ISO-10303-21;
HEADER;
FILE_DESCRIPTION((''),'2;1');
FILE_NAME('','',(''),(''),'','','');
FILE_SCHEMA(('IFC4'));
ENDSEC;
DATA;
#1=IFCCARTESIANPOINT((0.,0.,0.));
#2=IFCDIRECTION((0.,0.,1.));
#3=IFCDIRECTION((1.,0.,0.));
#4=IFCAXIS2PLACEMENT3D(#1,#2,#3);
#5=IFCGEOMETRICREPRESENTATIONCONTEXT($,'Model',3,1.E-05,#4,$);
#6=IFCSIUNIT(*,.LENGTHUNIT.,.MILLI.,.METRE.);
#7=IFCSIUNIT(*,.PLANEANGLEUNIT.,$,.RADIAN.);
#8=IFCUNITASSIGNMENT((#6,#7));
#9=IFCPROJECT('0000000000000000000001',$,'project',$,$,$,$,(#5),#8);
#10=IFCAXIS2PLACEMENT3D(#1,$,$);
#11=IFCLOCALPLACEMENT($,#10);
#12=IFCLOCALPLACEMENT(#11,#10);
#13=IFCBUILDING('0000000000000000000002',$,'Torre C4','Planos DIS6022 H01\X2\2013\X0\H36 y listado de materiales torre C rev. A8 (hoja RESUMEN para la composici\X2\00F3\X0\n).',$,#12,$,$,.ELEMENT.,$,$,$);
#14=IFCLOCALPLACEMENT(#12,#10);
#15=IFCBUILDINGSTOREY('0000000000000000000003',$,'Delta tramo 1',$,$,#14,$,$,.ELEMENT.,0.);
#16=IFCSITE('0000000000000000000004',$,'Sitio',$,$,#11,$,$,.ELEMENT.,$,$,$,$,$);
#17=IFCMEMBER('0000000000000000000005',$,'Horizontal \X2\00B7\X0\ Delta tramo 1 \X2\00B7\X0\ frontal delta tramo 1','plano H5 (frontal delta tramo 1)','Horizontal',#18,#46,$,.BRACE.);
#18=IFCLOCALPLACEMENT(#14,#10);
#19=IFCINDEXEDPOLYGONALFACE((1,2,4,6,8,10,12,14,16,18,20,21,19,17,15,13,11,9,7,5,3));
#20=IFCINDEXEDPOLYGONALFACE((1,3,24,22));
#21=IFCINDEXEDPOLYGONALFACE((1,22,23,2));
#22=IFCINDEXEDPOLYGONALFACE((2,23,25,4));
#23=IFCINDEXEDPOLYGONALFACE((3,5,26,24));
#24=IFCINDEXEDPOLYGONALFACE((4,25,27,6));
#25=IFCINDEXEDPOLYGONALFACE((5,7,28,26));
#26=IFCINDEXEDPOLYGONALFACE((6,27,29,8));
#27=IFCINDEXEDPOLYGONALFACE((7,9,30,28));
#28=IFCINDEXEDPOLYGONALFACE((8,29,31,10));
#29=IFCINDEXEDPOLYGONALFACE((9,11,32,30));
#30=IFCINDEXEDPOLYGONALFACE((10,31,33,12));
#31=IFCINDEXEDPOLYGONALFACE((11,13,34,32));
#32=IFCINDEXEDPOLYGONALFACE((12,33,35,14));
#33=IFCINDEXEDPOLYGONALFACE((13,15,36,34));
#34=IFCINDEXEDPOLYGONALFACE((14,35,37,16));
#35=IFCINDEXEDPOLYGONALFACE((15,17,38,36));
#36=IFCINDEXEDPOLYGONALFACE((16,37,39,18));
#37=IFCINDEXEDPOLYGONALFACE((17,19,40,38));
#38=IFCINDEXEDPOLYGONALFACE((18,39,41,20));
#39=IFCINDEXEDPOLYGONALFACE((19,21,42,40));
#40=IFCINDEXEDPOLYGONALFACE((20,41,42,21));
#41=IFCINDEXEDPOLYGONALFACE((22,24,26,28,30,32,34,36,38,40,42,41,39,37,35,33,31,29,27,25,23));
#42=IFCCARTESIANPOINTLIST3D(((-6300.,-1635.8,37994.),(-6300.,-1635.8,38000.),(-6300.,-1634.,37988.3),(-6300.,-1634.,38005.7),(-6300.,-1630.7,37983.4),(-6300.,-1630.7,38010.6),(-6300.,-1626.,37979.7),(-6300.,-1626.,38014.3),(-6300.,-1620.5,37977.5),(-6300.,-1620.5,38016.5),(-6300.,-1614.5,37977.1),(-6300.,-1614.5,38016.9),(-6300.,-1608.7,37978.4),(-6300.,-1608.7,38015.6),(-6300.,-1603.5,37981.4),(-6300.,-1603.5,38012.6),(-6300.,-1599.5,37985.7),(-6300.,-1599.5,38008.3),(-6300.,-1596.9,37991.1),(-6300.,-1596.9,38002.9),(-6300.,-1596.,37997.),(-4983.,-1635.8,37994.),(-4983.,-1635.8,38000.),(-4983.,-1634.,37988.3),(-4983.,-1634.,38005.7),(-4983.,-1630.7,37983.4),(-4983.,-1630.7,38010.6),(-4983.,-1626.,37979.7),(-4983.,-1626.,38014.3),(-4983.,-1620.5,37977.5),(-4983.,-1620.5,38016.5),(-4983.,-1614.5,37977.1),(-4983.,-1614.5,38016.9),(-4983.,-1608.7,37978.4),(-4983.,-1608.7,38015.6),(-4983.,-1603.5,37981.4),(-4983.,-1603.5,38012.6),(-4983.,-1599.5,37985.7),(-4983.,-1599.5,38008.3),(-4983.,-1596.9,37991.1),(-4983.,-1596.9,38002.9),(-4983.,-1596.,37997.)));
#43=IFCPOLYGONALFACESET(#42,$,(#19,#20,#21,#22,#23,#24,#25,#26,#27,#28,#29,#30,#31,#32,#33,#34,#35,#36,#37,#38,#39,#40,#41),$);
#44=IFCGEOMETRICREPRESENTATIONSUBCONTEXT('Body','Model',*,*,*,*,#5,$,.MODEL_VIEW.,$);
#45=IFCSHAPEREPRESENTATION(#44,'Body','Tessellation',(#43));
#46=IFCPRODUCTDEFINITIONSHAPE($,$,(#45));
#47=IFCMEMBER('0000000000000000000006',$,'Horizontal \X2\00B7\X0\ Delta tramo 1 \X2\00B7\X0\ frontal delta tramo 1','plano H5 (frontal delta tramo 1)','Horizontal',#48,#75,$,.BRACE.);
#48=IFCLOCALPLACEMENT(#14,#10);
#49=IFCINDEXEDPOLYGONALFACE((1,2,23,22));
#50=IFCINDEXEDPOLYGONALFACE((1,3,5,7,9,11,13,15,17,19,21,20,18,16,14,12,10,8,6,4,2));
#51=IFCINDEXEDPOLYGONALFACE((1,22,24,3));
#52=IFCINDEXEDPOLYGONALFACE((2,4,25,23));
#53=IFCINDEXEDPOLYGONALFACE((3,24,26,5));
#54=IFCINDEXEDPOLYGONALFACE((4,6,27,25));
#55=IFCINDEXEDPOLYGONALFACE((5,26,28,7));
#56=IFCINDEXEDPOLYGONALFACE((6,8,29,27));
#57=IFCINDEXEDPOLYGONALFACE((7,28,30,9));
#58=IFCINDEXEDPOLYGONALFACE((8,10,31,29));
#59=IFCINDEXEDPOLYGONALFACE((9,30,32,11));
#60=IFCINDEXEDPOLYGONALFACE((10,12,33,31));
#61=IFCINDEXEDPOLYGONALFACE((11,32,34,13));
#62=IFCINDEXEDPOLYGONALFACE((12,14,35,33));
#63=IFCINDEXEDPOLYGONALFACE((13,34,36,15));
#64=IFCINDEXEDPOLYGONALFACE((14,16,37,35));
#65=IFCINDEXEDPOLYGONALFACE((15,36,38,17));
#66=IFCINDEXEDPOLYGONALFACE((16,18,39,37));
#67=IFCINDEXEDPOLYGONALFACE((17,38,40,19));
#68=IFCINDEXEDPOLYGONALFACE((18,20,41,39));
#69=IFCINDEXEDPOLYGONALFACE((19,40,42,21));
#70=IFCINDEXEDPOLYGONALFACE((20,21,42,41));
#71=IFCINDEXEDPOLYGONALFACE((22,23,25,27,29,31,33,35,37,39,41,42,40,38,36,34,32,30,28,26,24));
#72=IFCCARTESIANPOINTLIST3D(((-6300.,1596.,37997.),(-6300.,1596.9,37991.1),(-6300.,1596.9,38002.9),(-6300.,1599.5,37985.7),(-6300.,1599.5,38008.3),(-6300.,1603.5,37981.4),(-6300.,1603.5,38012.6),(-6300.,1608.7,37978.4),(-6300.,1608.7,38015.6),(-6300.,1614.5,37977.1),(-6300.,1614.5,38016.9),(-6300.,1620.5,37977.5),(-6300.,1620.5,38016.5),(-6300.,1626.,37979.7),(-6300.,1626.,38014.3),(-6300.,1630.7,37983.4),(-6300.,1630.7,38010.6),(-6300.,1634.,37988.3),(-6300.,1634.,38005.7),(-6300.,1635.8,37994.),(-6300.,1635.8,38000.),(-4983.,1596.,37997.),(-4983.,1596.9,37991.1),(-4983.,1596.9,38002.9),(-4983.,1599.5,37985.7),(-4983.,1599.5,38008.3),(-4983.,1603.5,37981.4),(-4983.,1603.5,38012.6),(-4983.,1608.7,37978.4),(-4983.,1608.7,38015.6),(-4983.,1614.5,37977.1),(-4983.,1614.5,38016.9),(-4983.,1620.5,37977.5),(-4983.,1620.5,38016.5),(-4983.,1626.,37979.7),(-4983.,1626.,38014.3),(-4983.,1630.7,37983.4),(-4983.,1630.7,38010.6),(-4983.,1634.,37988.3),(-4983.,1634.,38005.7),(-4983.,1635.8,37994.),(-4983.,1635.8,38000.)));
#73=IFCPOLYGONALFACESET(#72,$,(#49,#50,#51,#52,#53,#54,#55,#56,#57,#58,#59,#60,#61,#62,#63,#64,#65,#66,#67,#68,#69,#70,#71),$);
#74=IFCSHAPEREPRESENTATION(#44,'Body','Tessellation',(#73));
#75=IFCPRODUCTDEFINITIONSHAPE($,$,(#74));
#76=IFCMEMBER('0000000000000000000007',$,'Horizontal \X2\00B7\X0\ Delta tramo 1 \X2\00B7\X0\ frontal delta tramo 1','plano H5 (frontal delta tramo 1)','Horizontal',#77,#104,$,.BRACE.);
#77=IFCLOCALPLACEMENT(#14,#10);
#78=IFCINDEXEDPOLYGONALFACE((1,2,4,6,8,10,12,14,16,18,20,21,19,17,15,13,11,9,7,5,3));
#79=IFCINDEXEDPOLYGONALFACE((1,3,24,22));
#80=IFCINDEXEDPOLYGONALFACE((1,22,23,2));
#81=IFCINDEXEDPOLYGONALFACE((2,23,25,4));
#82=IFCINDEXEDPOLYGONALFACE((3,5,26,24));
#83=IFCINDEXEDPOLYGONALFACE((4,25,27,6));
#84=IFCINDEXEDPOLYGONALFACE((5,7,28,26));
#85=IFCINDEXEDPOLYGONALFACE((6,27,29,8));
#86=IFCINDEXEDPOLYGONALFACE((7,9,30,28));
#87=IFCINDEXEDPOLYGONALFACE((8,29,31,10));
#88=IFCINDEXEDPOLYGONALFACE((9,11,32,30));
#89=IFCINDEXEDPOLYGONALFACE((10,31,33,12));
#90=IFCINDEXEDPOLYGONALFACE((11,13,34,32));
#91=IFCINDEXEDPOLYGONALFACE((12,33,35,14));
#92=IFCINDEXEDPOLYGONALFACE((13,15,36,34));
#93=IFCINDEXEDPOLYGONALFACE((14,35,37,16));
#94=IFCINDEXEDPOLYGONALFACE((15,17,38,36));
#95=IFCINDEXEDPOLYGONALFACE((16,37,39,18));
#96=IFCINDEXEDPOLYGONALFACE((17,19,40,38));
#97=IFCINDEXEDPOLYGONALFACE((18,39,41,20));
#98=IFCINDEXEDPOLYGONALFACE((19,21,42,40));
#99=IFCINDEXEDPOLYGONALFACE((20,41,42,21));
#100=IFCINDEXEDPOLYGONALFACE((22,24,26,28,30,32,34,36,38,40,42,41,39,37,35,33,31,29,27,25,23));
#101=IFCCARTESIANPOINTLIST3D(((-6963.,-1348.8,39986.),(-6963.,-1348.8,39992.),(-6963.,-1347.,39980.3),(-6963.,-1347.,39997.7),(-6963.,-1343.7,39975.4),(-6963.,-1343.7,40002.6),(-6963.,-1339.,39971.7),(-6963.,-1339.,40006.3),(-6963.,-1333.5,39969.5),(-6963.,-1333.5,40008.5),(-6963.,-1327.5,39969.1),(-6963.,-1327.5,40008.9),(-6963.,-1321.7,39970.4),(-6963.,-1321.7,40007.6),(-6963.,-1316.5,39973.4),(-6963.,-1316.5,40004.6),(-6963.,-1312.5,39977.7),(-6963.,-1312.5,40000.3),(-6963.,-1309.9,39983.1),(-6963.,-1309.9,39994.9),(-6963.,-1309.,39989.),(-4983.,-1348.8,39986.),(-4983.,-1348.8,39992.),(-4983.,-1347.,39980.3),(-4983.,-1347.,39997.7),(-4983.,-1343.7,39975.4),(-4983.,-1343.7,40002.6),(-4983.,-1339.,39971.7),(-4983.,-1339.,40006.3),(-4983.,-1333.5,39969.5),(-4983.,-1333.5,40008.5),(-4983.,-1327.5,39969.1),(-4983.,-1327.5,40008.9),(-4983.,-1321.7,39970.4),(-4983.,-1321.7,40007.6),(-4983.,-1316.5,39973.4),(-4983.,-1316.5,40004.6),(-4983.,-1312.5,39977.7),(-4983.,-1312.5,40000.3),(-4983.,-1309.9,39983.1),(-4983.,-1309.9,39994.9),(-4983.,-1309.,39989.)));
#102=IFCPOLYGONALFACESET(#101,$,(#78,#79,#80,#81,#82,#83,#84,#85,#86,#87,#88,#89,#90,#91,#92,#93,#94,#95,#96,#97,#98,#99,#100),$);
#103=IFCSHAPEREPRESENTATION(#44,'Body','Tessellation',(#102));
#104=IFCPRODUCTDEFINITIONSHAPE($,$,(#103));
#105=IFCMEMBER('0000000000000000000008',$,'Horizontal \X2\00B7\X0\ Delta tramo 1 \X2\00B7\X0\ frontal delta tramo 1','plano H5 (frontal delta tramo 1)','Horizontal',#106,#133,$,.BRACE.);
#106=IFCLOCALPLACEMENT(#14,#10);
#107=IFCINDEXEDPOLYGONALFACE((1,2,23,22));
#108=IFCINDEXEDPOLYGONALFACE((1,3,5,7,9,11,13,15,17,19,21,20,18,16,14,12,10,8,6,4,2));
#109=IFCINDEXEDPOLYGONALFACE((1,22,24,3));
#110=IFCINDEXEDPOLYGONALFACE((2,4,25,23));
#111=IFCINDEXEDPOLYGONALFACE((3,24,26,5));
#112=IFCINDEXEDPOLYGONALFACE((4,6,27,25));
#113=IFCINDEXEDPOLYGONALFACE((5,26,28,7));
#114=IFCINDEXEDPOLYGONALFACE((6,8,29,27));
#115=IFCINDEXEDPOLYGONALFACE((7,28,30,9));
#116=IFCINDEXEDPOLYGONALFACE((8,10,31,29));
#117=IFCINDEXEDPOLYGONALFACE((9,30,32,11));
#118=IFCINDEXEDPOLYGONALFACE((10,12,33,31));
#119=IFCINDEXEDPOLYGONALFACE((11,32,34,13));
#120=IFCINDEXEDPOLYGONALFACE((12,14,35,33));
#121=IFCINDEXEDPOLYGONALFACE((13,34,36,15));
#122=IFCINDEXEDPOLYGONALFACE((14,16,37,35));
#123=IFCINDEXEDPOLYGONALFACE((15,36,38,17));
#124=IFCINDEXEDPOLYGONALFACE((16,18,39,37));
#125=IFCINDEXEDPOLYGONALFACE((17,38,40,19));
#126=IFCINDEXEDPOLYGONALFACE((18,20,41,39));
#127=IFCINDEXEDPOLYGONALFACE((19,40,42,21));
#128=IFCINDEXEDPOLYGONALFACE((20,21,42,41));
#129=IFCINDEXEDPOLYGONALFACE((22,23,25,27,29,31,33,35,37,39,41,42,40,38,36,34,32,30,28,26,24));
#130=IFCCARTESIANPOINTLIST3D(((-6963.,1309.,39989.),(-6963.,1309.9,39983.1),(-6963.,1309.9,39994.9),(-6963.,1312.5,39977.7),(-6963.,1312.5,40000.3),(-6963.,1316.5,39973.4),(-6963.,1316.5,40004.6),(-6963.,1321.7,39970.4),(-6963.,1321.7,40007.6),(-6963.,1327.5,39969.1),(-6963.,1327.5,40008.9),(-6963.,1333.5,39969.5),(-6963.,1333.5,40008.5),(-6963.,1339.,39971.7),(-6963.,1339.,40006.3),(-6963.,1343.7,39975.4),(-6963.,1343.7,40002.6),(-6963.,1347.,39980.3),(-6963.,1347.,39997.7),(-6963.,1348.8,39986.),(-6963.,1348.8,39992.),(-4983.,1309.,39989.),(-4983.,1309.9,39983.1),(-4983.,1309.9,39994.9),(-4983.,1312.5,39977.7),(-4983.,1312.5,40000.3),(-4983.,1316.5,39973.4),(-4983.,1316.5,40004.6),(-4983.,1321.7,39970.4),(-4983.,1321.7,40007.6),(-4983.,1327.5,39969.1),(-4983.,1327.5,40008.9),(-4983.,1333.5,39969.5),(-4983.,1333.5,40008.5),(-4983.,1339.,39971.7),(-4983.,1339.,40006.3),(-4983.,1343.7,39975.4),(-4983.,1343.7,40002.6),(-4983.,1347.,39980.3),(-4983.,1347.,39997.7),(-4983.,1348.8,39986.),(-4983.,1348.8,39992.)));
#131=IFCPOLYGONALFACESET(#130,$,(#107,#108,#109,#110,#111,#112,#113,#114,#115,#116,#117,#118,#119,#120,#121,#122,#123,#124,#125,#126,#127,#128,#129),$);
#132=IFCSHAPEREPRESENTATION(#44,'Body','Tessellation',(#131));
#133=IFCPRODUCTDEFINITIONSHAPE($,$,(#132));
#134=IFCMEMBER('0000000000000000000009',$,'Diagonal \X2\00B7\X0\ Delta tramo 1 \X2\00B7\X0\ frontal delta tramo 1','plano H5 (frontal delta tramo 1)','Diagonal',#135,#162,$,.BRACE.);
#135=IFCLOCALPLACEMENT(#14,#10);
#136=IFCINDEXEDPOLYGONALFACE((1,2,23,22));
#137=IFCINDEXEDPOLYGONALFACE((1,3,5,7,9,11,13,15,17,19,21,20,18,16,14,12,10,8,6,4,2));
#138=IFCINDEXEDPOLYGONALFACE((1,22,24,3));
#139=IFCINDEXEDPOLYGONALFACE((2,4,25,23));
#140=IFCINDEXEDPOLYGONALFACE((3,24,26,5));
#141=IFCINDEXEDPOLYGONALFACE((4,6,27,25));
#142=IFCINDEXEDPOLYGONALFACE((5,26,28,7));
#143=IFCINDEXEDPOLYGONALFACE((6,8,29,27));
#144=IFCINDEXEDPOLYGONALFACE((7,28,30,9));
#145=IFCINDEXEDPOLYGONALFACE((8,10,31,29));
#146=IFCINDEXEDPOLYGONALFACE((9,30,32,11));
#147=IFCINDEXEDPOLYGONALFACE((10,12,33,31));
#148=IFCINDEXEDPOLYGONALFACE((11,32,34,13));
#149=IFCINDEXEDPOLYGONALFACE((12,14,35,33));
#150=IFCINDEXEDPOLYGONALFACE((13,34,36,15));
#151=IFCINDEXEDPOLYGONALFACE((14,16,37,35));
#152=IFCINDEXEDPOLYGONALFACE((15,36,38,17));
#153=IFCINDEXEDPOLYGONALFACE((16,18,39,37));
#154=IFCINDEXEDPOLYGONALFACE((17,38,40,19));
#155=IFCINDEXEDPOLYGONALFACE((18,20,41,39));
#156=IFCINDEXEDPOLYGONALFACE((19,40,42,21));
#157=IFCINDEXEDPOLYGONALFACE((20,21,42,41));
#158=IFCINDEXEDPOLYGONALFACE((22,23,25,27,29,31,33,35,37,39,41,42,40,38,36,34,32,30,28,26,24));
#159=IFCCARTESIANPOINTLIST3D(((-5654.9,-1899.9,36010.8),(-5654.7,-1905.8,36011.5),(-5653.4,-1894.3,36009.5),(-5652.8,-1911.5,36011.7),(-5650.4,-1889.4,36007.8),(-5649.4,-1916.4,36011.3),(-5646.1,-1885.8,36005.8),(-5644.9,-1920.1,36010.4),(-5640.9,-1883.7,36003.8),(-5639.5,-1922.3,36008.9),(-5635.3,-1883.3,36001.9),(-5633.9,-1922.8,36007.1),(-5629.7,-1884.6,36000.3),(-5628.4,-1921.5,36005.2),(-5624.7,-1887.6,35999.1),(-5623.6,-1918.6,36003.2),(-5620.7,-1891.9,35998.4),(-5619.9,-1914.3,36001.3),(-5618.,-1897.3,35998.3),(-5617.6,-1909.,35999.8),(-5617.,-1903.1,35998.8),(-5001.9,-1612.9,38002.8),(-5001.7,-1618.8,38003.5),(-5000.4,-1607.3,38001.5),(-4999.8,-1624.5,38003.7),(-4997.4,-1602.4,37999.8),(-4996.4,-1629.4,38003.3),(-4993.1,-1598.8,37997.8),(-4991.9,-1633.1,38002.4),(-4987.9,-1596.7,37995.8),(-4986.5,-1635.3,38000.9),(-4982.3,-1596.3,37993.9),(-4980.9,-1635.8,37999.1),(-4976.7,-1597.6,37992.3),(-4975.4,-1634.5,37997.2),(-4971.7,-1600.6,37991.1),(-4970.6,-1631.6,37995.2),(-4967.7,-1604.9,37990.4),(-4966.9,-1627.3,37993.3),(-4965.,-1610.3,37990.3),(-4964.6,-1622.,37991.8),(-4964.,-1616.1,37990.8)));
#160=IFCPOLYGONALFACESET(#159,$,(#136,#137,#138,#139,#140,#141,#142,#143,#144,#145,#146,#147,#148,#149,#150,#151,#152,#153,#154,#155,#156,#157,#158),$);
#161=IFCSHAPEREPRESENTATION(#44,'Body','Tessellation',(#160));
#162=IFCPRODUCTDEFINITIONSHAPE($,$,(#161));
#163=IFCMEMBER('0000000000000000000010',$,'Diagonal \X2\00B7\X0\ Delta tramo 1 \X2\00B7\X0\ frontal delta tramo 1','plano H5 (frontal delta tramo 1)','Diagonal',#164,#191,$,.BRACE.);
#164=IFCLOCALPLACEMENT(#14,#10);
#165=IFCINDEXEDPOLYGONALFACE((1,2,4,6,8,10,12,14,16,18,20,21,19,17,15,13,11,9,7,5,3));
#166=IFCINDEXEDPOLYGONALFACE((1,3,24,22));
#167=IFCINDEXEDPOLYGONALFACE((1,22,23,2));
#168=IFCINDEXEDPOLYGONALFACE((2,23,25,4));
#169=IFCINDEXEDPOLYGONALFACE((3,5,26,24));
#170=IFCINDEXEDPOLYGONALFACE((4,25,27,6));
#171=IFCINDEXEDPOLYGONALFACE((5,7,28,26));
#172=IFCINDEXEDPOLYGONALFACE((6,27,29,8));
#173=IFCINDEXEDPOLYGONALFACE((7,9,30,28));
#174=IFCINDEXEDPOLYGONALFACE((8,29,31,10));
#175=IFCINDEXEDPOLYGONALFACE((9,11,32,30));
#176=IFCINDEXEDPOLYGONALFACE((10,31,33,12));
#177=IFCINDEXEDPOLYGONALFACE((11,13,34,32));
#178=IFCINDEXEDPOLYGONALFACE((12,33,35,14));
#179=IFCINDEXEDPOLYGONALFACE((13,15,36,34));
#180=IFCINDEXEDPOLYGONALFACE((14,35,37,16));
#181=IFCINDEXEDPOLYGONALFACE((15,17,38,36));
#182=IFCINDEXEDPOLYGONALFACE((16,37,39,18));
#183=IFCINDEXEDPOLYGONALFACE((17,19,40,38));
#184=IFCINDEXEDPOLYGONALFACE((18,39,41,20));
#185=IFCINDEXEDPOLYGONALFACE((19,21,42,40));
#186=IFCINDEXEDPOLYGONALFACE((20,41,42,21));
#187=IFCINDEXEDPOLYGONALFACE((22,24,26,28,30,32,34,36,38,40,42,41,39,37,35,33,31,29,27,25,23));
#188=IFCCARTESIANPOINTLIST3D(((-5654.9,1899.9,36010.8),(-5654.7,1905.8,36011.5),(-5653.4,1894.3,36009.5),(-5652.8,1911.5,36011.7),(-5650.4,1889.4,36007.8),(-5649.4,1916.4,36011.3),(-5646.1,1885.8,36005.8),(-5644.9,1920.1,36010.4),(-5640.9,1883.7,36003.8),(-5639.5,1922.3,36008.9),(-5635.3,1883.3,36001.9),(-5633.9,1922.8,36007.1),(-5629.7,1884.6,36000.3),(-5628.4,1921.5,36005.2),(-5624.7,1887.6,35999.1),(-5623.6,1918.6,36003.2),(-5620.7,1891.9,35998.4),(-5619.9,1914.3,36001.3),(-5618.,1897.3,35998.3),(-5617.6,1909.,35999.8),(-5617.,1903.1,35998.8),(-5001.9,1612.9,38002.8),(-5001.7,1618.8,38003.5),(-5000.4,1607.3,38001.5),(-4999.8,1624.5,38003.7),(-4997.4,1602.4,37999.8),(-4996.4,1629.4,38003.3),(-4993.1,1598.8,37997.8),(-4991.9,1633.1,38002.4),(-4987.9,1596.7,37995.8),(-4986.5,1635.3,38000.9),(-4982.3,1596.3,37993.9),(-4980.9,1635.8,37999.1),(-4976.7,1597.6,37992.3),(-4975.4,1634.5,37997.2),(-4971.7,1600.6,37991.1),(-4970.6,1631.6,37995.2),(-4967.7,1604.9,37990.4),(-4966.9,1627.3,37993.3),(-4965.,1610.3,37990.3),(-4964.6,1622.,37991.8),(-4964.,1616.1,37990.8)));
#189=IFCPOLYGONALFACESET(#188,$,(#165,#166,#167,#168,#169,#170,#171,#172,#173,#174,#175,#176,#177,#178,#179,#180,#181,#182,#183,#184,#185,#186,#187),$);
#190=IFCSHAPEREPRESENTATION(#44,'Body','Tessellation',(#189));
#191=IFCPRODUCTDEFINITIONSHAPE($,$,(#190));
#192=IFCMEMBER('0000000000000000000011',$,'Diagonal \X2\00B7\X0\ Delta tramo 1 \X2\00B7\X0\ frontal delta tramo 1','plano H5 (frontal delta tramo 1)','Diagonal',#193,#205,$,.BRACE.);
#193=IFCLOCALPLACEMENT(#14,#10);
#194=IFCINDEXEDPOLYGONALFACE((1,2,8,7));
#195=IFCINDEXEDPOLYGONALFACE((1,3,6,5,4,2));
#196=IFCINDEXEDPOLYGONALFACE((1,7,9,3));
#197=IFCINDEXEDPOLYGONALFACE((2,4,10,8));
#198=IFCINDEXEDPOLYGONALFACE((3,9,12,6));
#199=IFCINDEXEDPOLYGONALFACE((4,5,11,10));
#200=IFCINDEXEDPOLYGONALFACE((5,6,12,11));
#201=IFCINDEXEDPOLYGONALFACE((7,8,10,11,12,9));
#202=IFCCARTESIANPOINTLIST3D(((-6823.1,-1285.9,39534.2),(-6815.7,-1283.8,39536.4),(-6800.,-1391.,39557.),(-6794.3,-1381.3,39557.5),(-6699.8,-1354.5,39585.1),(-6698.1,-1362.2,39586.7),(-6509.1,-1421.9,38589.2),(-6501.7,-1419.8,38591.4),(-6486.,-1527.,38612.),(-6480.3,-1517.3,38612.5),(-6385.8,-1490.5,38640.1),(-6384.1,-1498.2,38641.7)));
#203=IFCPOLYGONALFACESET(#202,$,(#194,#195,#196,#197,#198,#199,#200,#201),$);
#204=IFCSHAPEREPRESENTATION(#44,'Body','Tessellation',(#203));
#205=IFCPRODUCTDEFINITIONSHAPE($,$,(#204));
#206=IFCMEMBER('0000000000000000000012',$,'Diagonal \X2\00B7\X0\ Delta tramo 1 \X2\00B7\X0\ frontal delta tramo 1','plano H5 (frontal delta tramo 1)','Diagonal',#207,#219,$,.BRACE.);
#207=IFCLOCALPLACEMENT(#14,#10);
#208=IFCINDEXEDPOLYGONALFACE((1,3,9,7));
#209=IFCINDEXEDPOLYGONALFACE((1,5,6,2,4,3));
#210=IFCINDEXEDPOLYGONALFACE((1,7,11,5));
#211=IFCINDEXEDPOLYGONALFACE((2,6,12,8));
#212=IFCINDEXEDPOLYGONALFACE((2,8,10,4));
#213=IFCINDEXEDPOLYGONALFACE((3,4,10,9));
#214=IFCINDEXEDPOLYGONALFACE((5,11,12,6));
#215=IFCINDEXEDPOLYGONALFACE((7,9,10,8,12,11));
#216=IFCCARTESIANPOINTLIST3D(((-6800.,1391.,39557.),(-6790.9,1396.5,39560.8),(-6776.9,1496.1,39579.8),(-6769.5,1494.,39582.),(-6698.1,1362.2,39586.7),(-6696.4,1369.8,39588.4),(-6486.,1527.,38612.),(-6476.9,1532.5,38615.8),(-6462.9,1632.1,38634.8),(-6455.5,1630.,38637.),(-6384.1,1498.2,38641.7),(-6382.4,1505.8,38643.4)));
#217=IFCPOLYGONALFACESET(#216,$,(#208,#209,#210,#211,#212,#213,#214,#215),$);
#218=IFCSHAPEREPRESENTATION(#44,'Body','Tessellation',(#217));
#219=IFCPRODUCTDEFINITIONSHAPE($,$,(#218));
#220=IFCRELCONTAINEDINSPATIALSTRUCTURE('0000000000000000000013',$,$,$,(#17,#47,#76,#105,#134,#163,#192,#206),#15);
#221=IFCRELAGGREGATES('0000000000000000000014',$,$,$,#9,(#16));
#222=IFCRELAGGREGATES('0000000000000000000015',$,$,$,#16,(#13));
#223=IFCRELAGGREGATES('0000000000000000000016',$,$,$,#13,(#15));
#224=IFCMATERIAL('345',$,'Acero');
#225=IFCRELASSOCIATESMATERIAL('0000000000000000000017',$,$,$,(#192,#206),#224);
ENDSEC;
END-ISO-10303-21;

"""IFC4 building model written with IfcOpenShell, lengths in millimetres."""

from ifc_helpers import new_model, si_unit, frame, frame_2d, origin, origin_with_axes, place, context, subcontext, project, spatial, circle, l_section, extrude, material, element, save


model = new_model("IFC4")

# Units and contexts
model_context = context("Model", 3, precision=1e-05, world=origin_with_axes())
body_context = subcontext(model_context, "Body", "Model", "MODEL_VIEW")
ifc_project = project(units=[si_unit("LENGTHUNIT", "METRE", prefix="MILLI"), si_unit("PLANEANGLEUNIT", "RADIAN")], contexts=[model_context])

# Site, building, storey
site_placement = place(None, origin())
site = spatial("IfcSite", under=ifc_project, at=site_placement, Name="Sitio", CompositionType="ELEMENT")
building_placement = place(site_placement, origin())
building = spatial("IfcBuilding", under=site, at=building_placement, Name="Torre C4", Description="Planos DIS6022 H01–H36 y listado de materiales torre C rev. A8 (hoja RESUMEN para la composición).", CompositionType="ELEMENT")
storey_placement = place(building_placement, origin())
storey = spatial("IfcBuildingStorey", under=building, at=storey_placement, Name="Delta tramo 1", CompositionType="ELEMENT", Elevation=0.0)

# Members
for number, where, z_axis, x_axis, name in (
    (1, (-6300.0, -1616.0, 37997.0), (1.0, 0.0, 0.0), (0.0, 1.0, 0.0), "Horizontal · Delta tramo 1 · frontal delta tramo 1"),
    (2, (-6300.0, 1616.0, 37997.0), (1.0, 0.0, 0.0), (0.0, -1.0, 0.0), "Horizontal · Delta tramo 1 · frontal delta tramo 1"),
):
    element("IfcMember", number, at=place(storey_placement, frame(where, z_axis=z_axis, x_axis=x_axis)), inside=storey, Name=name, Description="plano H5 (frontal delta tramo 1)", ObjectType="Horizontal", PredefinedType="BRACE", context=body_context, shape_type="SweptSolid", body=[
        extrude(circle(Radius=20.0), None, (0.0, 0.0, 1.0), 1317.0),
    ])
for number, where, z_axis, x_axis, name in (
    (3, (-6963.0, -1329.0, 39989.0), (1.0, 0.0, 0.0), (0.0, 1.0, 0.0), "Horizontal · Delta tramo 1 · frontal delta tramo 1"),
    (4, (-6963.0, 1329.0, 39989.0), (1.0, 0.0, 0.0), (0.0, -1.0, 0.0), "Horizontal · Delta tramo 1 · frontal delta tramo 1"),
):
    element("IfcMember", number, at=place(storey_placement, frame(where, z_axis=z_axis, x_axis=x_axis)), inside=storey, Name=name, Description="plano H5 (frontal delta tramo 1)", ObjectType="Horizontal", PredefinedType="BRACE", context=body_context, shape_type="SweptSolid", body=[
        extrude(circle(Radius=20.0), None, (0.0, 0.0, 1.0), 1980.0),
    ])
for number, where, z_axis, x_axis, name in (
    (5, (-4983.0, -1616.0, 37997.0), (-0.308622, -0.135643, -0.941463), (0.897727, 0.285606, -0.335434), "Diagonal · Delta tramo 1 · frontal delta tramo 1"),
    (6, (-4983.0, 1616.0, 37997.0), (-0.308622, 0.135643, -0.941463), (0.897727, -0.285606, -0.335434), "Diagonal · Delta tramo 1 · frontal delta tramo 1"),
):
    element("IfcMember", number, at=place(storey_placement, frame(where, z_axis=z_axis, x_axis=x_axis)), inside=storey, Name=name, Description="plano H5 (frontal delta tramo 1)", ObjectType="Diagonal", PredefinedType="BRACE", context=body_context, shape_type="SweptSolid", body=[
        extrude(circle(Radius=20.0), None, (0.0, 0.0, 1.0), 2115.9),
    ])
ifc_material_1 = material(Name="345", Category="Acero")
for number, where, z_axis, x_axis, name in (
    (7, (-6486.0, -1527.0, 38612.0), (-0.312424, 0.135317, 0.940256), (0.926472, 0.26207, 0.270128), "Diagonal · Delta tramo 1 · frontal delta tramo 1"),
    (8, (-6486.0, 1527.0, 38612.0), (-0.312424, -0.135317, 0.940256), (0.926472, -0.26207, 0.270128), "Diagonal · Delta tramo 1 · frontal delta tramo 1"),
):
    element("IfcMember", number, at=place(storey_placement, frame(where, z_axis=z_axis, x_axis=x_axis)), inside=storey, material=ifc_material_1, Name=name, Description="plano H5 (frontal delta tramo 1)", ObjectType="Diagonal", PredefinedType="BRACE", context=body_context, shape_type="SweptSolid", body=[
        extrude(l_section(Depth=110.0, Width=110.0, Thickness=8.0, at=frame_2d((55.0, 55.0))), None, (0.0, 0.0, 1.0), 1005.0),
    ])

save(model, "model.ifc")
